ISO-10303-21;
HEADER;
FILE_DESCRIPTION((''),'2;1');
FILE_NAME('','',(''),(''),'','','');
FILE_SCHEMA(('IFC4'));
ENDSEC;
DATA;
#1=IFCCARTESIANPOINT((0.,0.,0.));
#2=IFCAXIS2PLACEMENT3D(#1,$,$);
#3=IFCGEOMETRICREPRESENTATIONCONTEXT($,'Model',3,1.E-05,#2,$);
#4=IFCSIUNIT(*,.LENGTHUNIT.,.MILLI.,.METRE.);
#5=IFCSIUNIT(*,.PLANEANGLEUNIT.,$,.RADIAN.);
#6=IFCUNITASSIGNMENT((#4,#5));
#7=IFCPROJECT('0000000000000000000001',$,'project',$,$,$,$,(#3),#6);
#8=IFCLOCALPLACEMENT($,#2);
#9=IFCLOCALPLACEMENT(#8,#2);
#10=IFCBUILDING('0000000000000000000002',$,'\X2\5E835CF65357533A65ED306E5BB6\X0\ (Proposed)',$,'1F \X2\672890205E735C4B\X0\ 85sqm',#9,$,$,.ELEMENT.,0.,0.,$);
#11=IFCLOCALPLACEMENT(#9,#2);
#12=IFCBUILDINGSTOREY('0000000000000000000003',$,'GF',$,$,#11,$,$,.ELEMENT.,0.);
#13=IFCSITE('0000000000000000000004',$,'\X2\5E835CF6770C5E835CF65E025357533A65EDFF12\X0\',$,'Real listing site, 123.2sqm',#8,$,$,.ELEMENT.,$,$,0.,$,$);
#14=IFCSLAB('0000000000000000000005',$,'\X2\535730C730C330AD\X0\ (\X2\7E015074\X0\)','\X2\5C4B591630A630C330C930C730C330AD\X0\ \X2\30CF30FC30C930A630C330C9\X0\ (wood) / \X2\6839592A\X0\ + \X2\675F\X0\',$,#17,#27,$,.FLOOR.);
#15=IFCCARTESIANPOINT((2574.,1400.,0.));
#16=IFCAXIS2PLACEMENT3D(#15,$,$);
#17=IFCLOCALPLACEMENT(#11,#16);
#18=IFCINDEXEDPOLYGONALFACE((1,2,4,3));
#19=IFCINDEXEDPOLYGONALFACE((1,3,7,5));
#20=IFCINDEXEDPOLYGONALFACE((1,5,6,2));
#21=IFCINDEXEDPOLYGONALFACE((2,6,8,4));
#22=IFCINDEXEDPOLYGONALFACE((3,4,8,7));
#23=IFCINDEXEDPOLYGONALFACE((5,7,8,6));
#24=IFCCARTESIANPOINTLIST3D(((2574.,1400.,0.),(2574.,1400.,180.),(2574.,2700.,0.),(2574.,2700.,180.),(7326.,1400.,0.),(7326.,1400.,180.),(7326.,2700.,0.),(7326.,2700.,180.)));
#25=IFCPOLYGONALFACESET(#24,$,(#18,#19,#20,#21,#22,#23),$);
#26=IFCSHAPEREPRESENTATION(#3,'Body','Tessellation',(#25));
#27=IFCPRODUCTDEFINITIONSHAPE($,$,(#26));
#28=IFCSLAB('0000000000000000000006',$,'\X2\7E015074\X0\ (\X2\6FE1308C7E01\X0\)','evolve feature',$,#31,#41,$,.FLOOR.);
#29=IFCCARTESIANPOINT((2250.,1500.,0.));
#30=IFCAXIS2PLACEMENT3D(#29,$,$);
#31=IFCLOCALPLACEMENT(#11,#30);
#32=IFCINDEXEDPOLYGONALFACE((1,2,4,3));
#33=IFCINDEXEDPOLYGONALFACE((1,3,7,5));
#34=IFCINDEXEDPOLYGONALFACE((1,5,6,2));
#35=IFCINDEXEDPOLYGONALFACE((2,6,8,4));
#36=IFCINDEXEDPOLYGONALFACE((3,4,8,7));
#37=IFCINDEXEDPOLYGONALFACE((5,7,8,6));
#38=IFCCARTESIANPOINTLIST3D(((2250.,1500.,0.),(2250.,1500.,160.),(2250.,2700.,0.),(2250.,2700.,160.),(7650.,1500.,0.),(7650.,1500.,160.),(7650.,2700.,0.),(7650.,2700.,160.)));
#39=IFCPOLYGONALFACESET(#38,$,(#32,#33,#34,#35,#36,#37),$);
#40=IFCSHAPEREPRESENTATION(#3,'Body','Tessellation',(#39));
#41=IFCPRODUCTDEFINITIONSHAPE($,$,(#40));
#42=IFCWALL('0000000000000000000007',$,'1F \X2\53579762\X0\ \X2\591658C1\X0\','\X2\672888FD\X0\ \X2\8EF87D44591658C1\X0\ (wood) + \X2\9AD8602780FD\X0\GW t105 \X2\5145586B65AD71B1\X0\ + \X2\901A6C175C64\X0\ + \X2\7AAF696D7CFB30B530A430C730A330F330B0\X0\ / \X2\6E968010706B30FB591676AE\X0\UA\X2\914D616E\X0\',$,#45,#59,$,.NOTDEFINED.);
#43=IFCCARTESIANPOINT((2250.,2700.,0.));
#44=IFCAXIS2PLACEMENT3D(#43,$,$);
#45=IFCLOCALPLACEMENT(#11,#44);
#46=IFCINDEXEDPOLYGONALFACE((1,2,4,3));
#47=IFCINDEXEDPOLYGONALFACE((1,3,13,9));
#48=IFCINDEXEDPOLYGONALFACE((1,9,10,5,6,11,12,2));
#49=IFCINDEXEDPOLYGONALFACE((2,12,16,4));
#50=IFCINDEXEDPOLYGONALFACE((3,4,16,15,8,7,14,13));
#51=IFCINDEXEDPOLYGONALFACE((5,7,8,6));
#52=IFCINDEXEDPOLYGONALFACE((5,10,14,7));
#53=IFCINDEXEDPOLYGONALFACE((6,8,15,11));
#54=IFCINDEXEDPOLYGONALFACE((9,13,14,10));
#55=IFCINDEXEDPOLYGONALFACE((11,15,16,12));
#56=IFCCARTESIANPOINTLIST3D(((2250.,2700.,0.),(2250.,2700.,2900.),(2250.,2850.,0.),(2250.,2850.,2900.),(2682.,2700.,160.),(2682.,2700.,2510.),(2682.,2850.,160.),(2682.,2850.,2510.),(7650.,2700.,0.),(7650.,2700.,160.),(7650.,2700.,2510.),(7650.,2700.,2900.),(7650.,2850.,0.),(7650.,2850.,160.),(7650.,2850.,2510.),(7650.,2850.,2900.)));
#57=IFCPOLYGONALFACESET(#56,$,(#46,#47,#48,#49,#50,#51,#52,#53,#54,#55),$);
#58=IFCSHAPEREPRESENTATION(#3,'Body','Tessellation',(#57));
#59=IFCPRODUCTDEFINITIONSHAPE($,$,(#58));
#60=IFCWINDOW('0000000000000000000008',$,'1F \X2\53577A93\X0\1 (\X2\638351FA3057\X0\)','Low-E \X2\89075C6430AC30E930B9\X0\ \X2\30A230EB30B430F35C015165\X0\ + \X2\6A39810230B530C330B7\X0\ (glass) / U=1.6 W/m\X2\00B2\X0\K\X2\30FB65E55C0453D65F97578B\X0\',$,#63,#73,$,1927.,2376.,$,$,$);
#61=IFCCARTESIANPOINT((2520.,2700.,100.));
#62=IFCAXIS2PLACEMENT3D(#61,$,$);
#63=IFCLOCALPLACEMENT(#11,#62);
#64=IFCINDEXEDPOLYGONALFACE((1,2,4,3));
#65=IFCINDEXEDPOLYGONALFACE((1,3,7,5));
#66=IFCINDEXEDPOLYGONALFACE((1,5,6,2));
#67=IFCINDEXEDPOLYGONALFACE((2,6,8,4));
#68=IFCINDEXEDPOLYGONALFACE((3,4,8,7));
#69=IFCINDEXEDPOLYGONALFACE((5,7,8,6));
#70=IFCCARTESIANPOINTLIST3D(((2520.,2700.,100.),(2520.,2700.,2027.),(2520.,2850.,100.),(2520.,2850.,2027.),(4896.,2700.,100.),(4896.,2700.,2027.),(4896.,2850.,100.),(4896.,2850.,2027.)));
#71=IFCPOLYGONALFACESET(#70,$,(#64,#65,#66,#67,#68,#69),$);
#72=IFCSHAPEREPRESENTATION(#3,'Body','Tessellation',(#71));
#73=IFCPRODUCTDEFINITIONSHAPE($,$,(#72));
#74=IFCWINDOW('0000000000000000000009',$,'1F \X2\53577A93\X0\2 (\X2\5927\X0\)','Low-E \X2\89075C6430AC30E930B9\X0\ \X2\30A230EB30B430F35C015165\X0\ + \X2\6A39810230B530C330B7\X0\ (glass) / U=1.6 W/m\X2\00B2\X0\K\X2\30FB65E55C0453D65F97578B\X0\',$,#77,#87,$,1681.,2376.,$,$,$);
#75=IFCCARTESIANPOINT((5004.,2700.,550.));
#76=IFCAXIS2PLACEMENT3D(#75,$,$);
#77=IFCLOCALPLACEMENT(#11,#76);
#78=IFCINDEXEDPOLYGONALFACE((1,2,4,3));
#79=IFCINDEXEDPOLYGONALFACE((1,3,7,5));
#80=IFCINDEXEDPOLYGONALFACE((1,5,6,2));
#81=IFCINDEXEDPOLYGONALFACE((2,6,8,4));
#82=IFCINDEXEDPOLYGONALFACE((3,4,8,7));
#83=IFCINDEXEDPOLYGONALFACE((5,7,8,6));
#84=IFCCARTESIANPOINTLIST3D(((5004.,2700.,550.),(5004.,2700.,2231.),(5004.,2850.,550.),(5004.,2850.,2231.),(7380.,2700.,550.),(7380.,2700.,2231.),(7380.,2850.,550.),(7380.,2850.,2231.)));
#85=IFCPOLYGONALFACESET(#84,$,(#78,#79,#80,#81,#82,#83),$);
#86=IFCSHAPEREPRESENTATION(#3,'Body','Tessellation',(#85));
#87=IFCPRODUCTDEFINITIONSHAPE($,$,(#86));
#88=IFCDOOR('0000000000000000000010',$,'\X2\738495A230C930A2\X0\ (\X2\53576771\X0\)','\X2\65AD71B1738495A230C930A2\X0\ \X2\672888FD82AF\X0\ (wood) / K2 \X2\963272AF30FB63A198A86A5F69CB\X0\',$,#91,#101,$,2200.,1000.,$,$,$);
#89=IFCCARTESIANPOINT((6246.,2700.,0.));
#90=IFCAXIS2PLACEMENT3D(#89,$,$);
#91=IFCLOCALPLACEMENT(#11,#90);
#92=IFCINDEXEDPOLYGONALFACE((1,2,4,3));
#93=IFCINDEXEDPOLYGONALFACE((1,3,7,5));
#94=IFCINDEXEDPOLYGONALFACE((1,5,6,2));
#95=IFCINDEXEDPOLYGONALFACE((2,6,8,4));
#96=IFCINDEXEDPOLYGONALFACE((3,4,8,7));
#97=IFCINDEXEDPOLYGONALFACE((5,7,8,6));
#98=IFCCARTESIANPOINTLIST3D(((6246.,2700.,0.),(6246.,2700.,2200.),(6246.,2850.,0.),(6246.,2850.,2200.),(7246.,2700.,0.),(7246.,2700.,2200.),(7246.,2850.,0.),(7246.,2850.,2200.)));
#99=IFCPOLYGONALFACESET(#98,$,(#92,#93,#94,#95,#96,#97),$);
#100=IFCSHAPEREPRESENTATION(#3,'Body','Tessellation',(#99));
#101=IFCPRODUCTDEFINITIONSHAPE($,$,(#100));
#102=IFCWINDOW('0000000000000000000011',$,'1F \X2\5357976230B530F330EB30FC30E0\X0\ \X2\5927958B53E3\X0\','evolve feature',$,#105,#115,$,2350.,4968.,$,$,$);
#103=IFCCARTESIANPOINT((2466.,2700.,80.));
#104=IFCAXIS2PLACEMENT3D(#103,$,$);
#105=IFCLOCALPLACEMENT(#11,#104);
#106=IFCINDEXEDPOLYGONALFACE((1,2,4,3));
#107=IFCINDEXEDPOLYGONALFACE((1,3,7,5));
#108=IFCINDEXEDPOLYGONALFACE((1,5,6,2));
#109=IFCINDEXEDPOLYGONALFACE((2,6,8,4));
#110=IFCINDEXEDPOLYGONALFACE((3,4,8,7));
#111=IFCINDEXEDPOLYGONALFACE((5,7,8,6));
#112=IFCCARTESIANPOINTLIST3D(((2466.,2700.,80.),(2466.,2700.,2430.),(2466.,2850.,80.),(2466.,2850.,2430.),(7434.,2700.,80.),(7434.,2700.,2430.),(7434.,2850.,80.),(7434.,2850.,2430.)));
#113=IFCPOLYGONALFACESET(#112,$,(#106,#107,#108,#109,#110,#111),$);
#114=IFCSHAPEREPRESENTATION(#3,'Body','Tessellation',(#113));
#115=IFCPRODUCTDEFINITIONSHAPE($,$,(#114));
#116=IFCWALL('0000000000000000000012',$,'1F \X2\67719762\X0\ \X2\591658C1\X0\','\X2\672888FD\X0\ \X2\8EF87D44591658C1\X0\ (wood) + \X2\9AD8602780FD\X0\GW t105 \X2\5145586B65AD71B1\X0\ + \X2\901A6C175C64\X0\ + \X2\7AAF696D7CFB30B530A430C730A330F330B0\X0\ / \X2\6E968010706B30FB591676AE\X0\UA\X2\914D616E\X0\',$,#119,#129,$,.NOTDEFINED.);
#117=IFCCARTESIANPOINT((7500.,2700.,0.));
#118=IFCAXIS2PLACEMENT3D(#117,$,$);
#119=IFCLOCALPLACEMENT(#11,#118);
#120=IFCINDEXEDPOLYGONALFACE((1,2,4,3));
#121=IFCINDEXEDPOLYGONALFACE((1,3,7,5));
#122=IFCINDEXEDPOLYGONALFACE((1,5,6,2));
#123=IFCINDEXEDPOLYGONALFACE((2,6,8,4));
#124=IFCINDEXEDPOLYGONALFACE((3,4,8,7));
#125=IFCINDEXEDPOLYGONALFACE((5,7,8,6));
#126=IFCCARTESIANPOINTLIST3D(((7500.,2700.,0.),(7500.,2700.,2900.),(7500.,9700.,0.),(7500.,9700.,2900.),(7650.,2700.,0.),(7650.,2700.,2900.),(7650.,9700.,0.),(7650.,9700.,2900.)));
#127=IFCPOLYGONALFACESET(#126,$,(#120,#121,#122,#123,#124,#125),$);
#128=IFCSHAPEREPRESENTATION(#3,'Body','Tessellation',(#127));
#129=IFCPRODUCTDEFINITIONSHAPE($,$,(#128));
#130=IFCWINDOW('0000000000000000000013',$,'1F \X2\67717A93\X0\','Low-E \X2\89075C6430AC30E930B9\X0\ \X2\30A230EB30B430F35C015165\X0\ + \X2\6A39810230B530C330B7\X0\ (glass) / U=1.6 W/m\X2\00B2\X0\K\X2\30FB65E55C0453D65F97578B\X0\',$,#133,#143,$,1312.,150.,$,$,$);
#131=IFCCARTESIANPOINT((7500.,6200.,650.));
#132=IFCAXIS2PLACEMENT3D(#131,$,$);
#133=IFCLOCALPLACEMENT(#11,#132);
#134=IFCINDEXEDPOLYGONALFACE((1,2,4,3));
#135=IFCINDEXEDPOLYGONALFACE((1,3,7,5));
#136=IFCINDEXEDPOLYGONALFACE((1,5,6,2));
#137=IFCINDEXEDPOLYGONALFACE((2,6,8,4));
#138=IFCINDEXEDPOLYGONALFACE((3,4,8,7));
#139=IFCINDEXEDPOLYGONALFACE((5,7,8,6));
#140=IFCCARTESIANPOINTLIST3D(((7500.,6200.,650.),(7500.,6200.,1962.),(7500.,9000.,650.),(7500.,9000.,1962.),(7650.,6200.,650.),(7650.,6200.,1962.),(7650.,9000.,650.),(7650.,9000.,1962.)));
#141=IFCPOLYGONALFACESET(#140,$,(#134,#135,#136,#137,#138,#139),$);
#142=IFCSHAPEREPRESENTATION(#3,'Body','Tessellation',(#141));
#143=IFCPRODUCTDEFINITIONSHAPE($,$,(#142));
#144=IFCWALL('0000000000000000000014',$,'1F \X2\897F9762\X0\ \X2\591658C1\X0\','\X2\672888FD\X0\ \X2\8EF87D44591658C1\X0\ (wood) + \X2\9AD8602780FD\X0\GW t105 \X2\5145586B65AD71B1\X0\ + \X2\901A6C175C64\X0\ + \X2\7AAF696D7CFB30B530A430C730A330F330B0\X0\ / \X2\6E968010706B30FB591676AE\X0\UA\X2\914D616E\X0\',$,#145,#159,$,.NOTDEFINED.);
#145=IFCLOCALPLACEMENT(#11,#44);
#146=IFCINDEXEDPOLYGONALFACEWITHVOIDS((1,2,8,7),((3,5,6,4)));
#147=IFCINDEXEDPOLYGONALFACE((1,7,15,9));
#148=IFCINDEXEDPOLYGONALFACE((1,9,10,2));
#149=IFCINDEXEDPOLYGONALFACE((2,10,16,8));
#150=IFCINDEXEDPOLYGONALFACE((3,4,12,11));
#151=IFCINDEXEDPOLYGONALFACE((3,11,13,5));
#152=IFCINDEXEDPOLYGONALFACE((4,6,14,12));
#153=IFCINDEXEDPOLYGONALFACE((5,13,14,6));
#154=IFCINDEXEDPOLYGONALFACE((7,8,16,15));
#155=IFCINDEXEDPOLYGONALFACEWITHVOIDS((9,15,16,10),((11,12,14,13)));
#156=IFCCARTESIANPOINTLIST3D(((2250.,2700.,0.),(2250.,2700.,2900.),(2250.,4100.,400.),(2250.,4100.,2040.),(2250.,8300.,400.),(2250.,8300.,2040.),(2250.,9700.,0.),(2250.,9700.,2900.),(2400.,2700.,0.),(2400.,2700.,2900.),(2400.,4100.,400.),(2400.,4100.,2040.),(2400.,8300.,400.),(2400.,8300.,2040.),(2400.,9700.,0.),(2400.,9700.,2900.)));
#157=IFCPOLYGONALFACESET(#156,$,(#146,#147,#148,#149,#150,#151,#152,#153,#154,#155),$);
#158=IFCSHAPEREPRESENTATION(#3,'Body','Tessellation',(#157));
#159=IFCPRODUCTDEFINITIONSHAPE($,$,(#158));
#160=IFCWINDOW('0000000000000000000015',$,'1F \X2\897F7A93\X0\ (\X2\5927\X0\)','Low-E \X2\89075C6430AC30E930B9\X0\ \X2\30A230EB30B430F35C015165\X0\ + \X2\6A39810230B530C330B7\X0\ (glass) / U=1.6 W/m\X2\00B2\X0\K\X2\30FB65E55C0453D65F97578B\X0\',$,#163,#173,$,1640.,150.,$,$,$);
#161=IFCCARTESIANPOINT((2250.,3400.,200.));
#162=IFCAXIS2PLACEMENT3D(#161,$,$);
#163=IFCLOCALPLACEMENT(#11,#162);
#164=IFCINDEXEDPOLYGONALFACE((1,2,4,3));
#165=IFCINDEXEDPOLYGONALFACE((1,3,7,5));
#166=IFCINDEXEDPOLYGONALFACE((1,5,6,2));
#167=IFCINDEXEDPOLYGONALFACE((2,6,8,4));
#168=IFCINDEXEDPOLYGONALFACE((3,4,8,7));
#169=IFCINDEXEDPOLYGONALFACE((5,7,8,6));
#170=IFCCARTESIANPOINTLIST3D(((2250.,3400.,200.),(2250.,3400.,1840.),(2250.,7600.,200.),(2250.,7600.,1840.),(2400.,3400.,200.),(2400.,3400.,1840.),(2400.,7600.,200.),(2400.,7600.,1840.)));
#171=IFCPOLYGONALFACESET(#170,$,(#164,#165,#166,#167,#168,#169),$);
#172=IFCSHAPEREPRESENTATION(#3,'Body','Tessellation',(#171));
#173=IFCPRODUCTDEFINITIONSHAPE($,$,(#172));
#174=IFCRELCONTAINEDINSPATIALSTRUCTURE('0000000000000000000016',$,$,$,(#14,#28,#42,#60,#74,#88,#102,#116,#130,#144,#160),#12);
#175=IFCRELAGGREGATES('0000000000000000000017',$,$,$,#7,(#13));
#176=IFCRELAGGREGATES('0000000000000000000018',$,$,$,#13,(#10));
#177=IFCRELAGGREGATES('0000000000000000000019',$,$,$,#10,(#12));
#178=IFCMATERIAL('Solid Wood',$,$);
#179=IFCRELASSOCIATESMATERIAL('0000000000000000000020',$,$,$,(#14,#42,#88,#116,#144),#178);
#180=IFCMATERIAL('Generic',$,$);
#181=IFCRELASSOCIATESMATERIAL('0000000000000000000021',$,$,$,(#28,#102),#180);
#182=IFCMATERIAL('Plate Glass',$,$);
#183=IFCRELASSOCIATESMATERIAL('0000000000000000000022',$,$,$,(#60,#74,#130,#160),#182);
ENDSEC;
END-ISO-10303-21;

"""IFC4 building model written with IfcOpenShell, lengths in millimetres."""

from ifc_helpers import new_model, si_unit, frame, frame_2d, origin, place, context, project, spatial, rectangle, extrude, material, element, fill, save


model = new_model("IFC4")

# Units and contexts
model_context = context("Model", 3, precision=1e-05, world=origin())
ifc_project = project(units=[si_unit("LENGTHUNIT", "METRE", prefix="MILLI"), si_unit("PLANEANGLEUNIT", "RADIAN")], contexts=[model_context])

# Site, building, storey
site_placement = place(None, origin())
site = spatial("IfcSite", under=ifc_project, at=site_placement, Name="広島県広島市南区旭２", ObjectType="Real listing site, 123.2sqm", CompositionType="ELEMENT", RefElevation=0.0)
building_placement = place(site_placement, origin())
building = spatial("IfcBuilding", under=site, at=building_placement, Name="広島南区旭の家 (Proposed)", ObjectType="1F 木造平屋 85sqm", CompositionType="ELEMENT", ElevationOfRefHeight=0.0, ElevationOfTerrain=0.0)
storey_placement = place(building_placement, origin())
storey = spatial("IfcBuildingStorey", under=building, at=storey_placement, Name="GF", CompositionType="ELEMENT", Elevation=0.0)

# Slabs
ifc_material_1 = material(Name="Solid Wood")
slab_1_placement = place(storey_placement, frame((2574.0, 1400.0, 0.0)))
element("IfcSlab", 1, at=slab_1_placement, inside=storey, material=ifc_material_1, Name="南デッキ (縁側)", Description="屋外ウッドデッキ ハードウッド (wood) / 根太 + 束", PredefinedType="FLOOR", context=model_context, shape_type="SweptSolid", body=[
    extrude(rectangle(XDim=4752.0, YDim=1300.0, at=frame_2d((2376.0, 650.0))), frame((2574.0, 1400.0, 0.0)), (0.0, 0.0, 1.0), 180.0),
])
ifc_material_2 = material(Name="Generic")
slab_2_placement = place(storey_placement, frame((2250.0, 1500.0, 0.0)))
element("IfcSlab", 2, at=slab_2_placement, inside=storey, material=ifc_material_2, Name="縁側 (濡れ縁)", Description="evolve feature", PredefinedType="FLOOR", context=model_context, shape_type="SweptSolid", body=[
    extrude(rectangle(XDim=5400.0, YDim=1200.0, at=frame_2d((2700.0, 600.0))), frame((2250.0, 1500.0, 0.0)), (0.0, 0.0, 1.0), 160.0),
])

# Wall, openings, windows, door
wall_1_placement = place(storey_placement, frame((2250.0, 2700.0, 0.0)))
wall_1 = element("IfcWall", 3, at=wall_1_placement, inside=storey, material=ifc_material_1, Name="1F 南面 外壁", Description="木製 軸組外壁 (wood) + 高性能GW t105 充填断熱 + 通気層 + 窯業系サイディング / 準耐火・外皮UA配慮", PredefinedType="NOTDEFINED", context=model_context, shape_type="SweptSolid", body=[
    extrude(rectangle(XDim=5400.0, YDim=150.0, at=frame_2d((2700.0, 75.0))), frame((2250.0, 2700.0, 0.0)), (0.0, 0.0, 1.0), 2900.0),
])
opening_1_placement = place(storey_placement, frame((2520.0, 2700.0, 100.0)))
opening_1 = element("IfcOpeningElement", 4, at=opening_1_placement, cuts=wall_1, PredefinedType="NOTDEFINED", context=model_context, shape_type="SweptSolid", body=[
    extrude(rectangle(XDim=2376.0, YDim=150.0, at=frame_2d((1188.0, 75.0))), frame((2520.0, 2700.0, 100.0)), (0.0, 0.0, 1.0), 1927.0),
])
opening_2_placement = place(storey_placement, frame((5004.0, 2700.0, 550.0)))
opening_2 = element("IfcOpeningElement", 5, at=opening_2_placement, cuts=wall_1, PredefinedType="NOTDEFINED", context=model_context, shape_type="SweptSolid", body=[
    extrude(rectangle(XDim=2376.0, YDim=150.0, at=frame_2d((1188.0, 75.0))), frame((5004.0, 2700.0, 550.0)), (0.0, 0.0, 1.0), 1681.0),
])
opening_3_placement = place(storey_placement, frame((6246.0, 2700.0, 0.0)))
opening_3 = element("IfcOpeningElement", 6, at=opening_3_placement, cuts=wall_1, PredefinedType="NOTDEFINED", context=model_context, shape_type="SweptSolid", body=[
    extrude(rectangle(XDim=1000.0, YDim=150.0, at=frame_2d((500.0, 75.0))), frame((6246.0, 2700.0, 0.0)), (0.0, 0.0, 1.0), 2200.0),
])
opening_4_placement = place(storey_placement, frame((2466.0, 2700.0, 80.0)))
opening_4 = element("IfcOpeningElement", 7, at=opening_4_placement, cuts=wall_1, PredefinedType="NOTDEFINED", context=model_context, shape_type="SweptSolid", body=[
    extrude(rectangle(XDim=4968.0, YDim=150.0, at=frame_2d((2484.0, 75.0))), frame((2466.0, 2700.0, 80.0)), (0.0, 0.0, 1.0), 2350.0),
])
ifc_material_3 = material(Name="Plate Glass")
window_1_placement = place(storey_placement, frame((2520.0, 2700.0, 100.0)))
window_1 = element("IfcWindow", 8, at=window_1_placement, inside=storey, material=ifc_material_3, Name="1F 南窓1 (掃出し)", Description="Low-E 複層ガラス アルゴン封入 + 樹脂サッシ (glass) / U=1.6 W/m²K・日射取得型", OverallHeight=1927.0, OverallWidth=2376.0, context=model_context, shape_type="SweptSolid", body=[
    extrude(rectangle(XDim=2376.0, YDim=150.0, at=frame_2d((1188.0, 75.0))), frame((2520.0, 2700.0, 100.0)), (0.0, 0.0, 1.0), 1927.0),
])
fill(opening_1, window_1)
window_2_placement = place(storey_placement, frame((5004.0, 2700.0, 550.0)))
window_2 = element("IfcWindow", 9, at=window_2_placement, inside=storey, material=ifc_material_3, Name="1F 南窓2 (大)", Description="Low-E 複層ガラス アルゴン封入 + 樹脂サッシ (glass) / U=1.6 W/m²K・日射取得型", OverallHeight=1681.0, OverallWidth=2376.0, context=model_context, shape_type="SweptSolid", body=[
    extrude(rectangle(XDim=2376.0, YDim=150.0, at=frame_2d((1188.0, 75.0))), frame((5004.0, 2700.0, 550.0)), (0.0, 0.0, 1.0), 1681.0),
])
fill(opening_2, window_2)
door_placement = place(storey_placement, frame((6246.0, 2700.0, 0.0)))
door = element("IfcDoor", 10, at=door_placement, inside=storey, material=ifc_material_1, Name="玄関ドア (南東)", Description="断熱玄関ドア 木製芯 (wood) / K2 防犯・採風機構", OverallHeight=2200.0, OverallWidth=1000.0, context=model_context, shape_type="SweptSolid", body=[
    extrude(rectangle(XDim=1000.0, YDim=150.0, at=frame_2d((500.0, 75.0))), frame((6246.0, 2700.0, 0.0)), (0.0, 0.0, 1.0), 2200.0),
])
fill(opening_3, door)
window_3_placement = place(storey_placement, frame((2466.0, 2700.0, 80.0)))
window_3 = element("IfcWindow", 11, at=window_3_placement, inside=storey, material=ifc_material_2, Name="1F 南面サンルーム 大開口", Description="evolve feature", OverallHeight=2350.0, OverallWidth=4968.0, context=model_context, shape_type="SweptSolid", body=[
    extrude(rectangle(XDim=4968.0, YDim=150.0, at=frame_2d((2484.0, 75.0))), frame((2466.0, 2700.0, 80.0)), (0.0, 0.0, 1.0), 2350.0),
])
fill(opening_4, window_3)

# Walls, openings, windows
wall_2_placement = place(storey_placement, frame((7500.0, 2700.0, 0.0)))
wall_2 = element("IfcWall", 12, at=wall_2_placement, inside=storey, material=ifc_material_1, Name="1F 東面 外壁", Description="木製 軸組外壁 (wood) + 高性能GW t105 充填断熱 + 通気層 + 窯業系サイディング / 準耐火・外皮UA配慮", PredefinedType="NOTDEFINED", context=model_context, shape_type="SweptSolid", body=[
    extrude(rectangle(XDim=150.0, YDim=7000.0, at=frame_2d((75.0, 3500.0))), frame((7500.0, 2700.0, 0.0)), (0.0, 0.0, 1.0), 2900.0),
])
opening_5_placement = place(storey_placement, frame((7500.0, 6200.0, 650.0)))
opening_5 = element("IfcOpeningElement", 13, at=opening_5_placement, cuts=wall_2, PredefinedType="NOTDEFINED", context=model_context, shape_type="SweptSolid", body=[
    extrude(rectangle(XDim=150.0, YDim=2800.0, at=frame_2d((75.0, 1400.0))), frame((7500.0, 6200.0, 650.0)), (0.0, 0.0, 1.0), 1312.0),
])
window_4_placement = place(storey_placement, frame((7500.0, 6200.0, 650.0)))
window_4 = element("IfcWindow", 14, at=window_4_placement, inside=storey, material=ifc_material_3, Name="1F 東窓", Description="Low-E 複層ガラス アルゴン封入 + 樹脂サッシ (glass) / U=1.6 W/m²K・日射取得型", OverallHeight=1312.0, OverallWidth=150.0, context=model_context, shape_type="SweptSolid", body=[
    extrude(rectangle(XDim=150.0, YDim=2800.0, at=frame_2d((75.0, 1400.0))), frame((7500.0, 6200.0, 650.0)), (0.0, 0.0, 1.0), 1312.0),
])
fill(opening_5, window_4)
wall_3_placement = place(storey_placement, frame((2250.0, 2700.0, 0.0)))
wall_3 = element("IfcWall", 15, at=wall_3_placement, inside=storey, material=ifc_material_1, Name="1F 西面 外壁", Description="木製 軸組外壁 (wood) + 高性能GW t105 充填断熱 + 通気層 + 窯業系サイディング / 準耐火・外皮UA配慮", PredefinedType="NOTDEFINED", context=model_context, shape_type="SweptSolid", body=[
    extrude(rectangle(XDim=150.0, YDim=7000.0, at=frame_2d((75.0, 3500.0))), frame((2250.0, 2700.0, 0.0)), (0.0, 0.0, 1.0), 2900.0),
])
opening_6_placement = place(storey_placement, frame((2250.0, 3400.0, 200.0)))
opening_6 = element("IfcOpeningElement", 16, at=opening_6_placement, cuts=wall_3, PredefinedType="NOTDEFINED", context=model_context, shape_type="SweptSolid", body=[
    extrude(rectangle(XDim=150.0, YDim=4200.0, at=frame_2d((75.0, 2100.0))), frame((2250.0, 3400.0, 200.0)), (0.0, 0.0, 1.0), 1640.0),
])
window_5_placement = place(storey_placement, frame((2250.0, 3400.0, 200.0)))
window_5 = element("IfcWindow", 17, at=window_5_placement, inside=storey, material=ifc_material_3, Name="1F 西窓 (大)", Description="Low-E 複層ガラス アルゴン封入 + 樹脂サッシ (glass) / U=1.6 W/m²K・日射取得型", OverallHeight=1640.0, OverallWidth=150.0, context=model_context, shape_type="SweptSolid", body=[
    extrude(rectangle(XDim=150.0, YDim=4200.0, at=frame_2d((75.0, 2100.0))), frame((2250.0, 3400.0, 200.0)), (0.0, 0.0, 1.0), 1640.0),
])
fill(opening_6, window_5)

save(model, "model.ifc")
